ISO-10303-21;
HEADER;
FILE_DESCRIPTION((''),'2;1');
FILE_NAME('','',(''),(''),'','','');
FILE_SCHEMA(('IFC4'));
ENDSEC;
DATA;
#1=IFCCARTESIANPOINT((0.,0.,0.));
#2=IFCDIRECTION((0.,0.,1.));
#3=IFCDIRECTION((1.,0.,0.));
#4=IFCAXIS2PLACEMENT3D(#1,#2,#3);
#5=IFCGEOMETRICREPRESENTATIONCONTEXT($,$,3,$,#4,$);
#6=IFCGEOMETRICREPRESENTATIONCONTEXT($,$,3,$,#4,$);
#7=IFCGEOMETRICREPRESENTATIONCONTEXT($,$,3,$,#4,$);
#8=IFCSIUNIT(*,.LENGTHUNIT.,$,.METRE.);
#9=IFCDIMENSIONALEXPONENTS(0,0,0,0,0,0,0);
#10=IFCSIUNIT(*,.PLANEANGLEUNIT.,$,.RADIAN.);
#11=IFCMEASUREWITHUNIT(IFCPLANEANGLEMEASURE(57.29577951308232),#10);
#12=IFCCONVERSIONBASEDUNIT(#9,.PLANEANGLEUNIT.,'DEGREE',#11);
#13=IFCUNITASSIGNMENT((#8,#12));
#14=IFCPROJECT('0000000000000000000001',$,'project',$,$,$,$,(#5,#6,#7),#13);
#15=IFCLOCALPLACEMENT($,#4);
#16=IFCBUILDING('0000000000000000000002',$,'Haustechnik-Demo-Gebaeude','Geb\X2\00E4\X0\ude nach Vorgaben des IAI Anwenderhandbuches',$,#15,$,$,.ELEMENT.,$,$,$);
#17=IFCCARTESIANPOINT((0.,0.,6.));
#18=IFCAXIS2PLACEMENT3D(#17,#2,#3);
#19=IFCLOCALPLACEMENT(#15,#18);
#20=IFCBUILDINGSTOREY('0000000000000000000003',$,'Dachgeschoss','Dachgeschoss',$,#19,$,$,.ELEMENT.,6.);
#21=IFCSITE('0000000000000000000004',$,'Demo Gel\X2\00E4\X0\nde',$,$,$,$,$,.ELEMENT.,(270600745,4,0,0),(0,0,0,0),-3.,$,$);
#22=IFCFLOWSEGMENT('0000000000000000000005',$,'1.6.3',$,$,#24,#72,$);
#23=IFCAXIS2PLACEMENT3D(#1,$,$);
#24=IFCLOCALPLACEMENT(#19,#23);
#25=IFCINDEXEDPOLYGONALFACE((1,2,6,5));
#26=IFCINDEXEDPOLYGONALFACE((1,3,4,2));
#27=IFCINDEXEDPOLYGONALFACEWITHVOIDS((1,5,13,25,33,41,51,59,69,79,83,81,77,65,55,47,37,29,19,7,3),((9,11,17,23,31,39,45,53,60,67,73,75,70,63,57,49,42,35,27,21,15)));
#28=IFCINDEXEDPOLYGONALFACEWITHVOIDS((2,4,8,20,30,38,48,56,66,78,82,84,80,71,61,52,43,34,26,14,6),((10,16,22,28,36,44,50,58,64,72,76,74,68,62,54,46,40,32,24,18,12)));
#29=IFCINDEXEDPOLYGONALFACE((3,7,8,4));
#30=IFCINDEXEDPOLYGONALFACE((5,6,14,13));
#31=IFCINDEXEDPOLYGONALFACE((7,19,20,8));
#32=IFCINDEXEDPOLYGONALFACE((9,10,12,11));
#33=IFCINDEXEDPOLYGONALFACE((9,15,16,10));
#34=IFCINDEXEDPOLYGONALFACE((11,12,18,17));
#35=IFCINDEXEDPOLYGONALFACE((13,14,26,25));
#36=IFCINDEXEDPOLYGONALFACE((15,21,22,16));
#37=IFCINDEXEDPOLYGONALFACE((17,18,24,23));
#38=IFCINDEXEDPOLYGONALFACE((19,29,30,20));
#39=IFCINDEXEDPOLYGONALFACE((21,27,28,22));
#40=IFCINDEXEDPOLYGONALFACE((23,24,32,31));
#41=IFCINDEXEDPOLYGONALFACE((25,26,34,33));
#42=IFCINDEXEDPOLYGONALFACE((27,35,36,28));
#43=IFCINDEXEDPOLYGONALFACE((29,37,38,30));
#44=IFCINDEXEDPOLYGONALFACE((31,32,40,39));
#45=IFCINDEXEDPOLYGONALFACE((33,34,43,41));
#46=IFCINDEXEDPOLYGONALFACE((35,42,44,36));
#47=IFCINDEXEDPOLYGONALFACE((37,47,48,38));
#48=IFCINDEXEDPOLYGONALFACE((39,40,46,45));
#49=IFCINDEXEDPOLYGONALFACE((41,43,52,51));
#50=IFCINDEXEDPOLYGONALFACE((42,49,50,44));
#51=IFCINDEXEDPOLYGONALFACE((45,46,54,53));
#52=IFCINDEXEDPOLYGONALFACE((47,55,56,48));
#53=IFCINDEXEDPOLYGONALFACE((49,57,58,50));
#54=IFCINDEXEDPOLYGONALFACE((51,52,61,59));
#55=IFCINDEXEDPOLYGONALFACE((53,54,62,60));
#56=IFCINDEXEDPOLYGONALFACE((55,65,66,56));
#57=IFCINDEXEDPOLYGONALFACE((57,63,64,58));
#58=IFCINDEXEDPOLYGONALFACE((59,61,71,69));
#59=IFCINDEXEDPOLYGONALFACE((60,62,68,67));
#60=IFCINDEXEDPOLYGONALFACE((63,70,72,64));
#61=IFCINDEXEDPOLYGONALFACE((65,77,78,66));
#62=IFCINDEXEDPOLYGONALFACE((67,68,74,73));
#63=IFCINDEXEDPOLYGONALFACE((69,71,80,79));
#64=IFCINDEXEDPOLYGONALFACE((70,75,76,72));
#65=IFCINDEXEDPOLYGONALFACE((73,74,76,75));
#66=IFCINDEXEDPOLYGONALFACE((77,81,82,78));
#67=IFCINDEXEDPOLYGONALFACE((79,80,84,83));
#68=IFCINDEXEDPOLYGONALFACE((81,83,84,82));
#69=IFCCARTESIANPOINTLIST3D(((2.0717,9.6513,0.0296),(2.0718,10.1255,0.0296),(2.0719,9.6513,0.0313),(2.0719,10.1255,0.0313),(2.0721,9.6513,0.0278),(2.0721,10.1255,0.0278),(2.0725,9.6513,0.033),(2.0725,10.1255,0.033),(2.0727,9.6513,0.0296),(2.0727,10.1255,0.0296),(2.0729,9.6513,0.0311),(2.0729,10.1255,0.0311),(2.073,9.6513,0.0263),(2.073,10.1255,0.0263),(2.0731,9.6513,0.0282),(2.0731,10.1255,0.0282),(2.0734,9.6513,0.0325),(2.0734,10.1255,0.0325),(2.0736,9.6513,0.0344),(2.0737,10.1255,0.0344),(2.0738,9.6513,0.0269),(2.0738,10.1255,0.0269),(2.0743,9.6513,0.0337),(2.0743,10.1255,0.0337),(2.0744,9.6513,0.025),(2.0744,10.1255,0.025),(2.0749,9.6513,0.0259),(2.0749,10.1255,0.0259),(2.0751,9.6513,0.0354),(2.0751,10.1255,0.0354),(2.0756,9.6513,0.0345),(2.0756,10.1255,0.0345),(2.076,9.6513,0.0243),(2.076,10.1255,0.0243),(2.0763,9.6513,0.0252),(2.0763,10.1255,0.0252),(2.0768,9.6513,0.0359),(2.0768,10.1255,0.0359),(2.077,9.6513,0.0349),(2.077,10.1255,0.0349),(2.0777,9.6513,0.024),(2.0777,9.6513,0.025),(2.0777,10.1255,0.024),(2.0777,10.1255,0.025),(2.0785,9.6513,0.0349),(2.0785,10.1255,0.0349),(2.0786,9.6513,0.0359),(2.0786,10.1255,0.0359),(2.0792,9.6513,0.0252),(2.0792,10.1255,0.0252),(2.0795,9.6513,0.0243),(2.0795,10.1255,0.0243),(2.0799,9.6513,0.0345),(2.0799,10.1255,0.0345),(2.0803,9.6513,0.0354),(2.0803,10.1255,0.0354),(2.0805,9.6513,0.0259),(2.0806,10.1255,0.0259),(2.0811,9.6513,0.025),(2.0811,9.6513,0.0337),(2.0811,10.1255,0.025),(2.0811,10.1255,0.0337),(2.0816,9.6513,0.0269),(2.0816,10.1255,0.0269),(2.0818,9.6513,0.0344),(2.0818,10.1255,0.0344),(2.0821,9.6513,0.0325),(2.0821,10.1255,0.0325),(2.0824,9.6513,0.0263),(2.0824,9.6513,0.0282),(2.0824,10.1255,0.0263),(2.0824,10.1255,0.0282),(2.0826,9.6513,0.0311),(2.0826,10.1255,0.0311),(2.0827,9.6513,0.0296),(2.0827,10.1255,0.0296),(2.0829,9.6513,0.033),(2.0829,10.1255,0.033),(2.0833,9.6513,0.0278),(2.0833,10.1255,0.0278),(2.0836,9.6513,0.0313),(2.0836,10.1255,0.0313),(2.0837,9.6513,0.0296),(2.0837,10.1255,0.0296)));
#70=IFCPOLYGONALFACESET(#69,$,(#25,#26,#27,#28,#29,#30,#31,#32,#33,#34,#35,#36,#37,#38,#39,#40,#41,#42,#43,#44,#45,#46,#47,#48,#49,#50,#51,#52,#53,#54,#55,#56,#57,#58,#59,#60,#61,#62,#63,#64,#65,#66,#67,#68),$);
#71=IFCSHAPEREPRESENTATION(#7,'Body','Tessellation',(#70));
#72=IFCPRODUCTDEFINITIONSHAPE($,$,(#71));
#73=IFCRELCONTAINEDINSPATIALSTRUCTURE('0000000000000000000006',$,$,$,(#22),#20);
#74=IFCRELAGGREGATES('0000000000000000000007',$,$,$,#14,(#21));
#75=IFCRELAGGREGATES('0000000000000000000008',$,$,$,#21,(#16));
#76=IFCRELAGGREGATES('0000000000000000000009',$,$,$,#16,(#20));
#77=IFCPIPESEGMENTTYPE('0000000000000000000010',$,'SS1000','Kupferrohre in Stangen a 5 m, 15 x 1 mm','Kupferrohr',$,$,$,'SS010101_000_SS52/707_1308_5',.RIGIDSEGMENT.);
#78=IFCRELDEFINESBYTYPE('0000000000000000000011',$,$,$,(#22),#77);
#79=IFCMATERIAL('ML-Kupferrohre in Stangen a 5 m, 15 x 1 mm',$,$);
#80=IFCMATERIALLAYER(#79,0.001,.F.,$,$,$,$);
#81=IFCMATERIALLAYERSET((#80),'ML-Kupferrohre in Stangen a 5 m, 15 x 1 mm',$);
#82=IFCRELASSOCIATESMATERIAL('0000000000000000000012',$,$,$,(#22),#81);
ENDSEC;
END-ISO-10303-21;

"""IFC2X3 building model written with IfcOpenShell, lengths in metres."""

from ifc_helpers import new_model, entity, si_unit, converted_unit, frame, origin_with_axes, origin_2d_with_axis, place, context, project, spatial, hollow_circle, extrude, material, layer, layer_set, layer_usage, type_object, element, save


model = new_model("IFC2X3")

# Units and contexts
context_of_model_1 = context(None, 3, world=origin_with_axes())
context_of_model_2 = context(None, 3, world=origin_with_axes())
context_of_model_3 = context(None, 3, world=origin_with_axes())
ifc_project = project(units=[si_unit("LENGTHUNIT", "METRE"), converted_unit("PLANEANGLEUNIT", "DEGREE", entity("IfcPlaneAngleMeasure", 57.29577951308232), si_unit("PLANEANGLEUNIT", "RADIAN"), dimensions=[0, 0, 0, 0, 0, 0, 0])], contexts=[context_of_model_1, context_of_model_2, context_of_model_3])

# Site, building, storey
site = spatial("IfcSite", under=ifc_project, Name="Demo Gelände", CompositionType="ELEMENT", RefLatitude=(270600745, 4, 0, 0), RefLongitude=(0, 0, 0, 0), RefElevation=-3.0)
building_placement = place(None, origin_with_axes())
building = spatial("IfcBuilding", under=site, at=building_placement, Name="Haustechnik-Demo-Gebaeude", Description="Gebäude nach Vorgaben des IAI Anwenderhandbuches", CompositionType="ELEMENT")
storey_placement = place(building_placement, frame((0.0, 0.0, 6.0), z_axis=(0.0, 0.0, 1.0), x_axis=(1.0, 0.0, 0.0)))
storey = spatial("IfcBuildingStorey", under=building, at=storey_placement, Name="Dachgeschoss", Description="Dachgeschoss", CompositionType="ELEMENT", Elevation=6.0)

# Flow segment
ifc_material = material(Name="ML-Kupferrohre in Stangen a 5 m, 15 x 1 mm")
ifc_layer = layer(ifc_material, 0.001, ventilated=False)
ifc_layer_set = layer_set([ifc_layer], Name="ML-Kupferrohre in Stangen a 5 m, 15 x 1 mm")
ifc_layer_usage = layer_usage(ifc_layer_set, "AXIS2", "POSITIVE", 0.0)
pipe_segment_type_1 = type_object("IfcPipeSegmentType", Name="SS1000", Description="Kupferrohre in Stangen a 5 m, 15 x 1 mm", ApplicableOccurrence="Kupferrohr", ElementType="SS010101_000_SS52/707_1308_5", PredefinedType="RIGIDSEGMENT")
flow_segment_1_placement = place(storey_placement, frame((2.0777, 10.1255, 0.03), z_axis=(-0.000008, -1.0, 0.0), x_axis=(0.0, 0.0, -1.0)))
element("IfcFlowSegment", 1, at=flow_segment_1_placement, inside=storey, type_object=pipe_segment_type_1, material=ifc_layer_usage, Name="1.6.3", context=context_of_model_3, shape_type="SweptSolid", body=[
    extrude(hollow_circle(Radius=0.006, WallThickness=0.001, at=origin_2d_with_axis()), origin_with_axes(), (0.0, 0.0, 1.0), 0.4742),
])

save(model, "model.ifc")
